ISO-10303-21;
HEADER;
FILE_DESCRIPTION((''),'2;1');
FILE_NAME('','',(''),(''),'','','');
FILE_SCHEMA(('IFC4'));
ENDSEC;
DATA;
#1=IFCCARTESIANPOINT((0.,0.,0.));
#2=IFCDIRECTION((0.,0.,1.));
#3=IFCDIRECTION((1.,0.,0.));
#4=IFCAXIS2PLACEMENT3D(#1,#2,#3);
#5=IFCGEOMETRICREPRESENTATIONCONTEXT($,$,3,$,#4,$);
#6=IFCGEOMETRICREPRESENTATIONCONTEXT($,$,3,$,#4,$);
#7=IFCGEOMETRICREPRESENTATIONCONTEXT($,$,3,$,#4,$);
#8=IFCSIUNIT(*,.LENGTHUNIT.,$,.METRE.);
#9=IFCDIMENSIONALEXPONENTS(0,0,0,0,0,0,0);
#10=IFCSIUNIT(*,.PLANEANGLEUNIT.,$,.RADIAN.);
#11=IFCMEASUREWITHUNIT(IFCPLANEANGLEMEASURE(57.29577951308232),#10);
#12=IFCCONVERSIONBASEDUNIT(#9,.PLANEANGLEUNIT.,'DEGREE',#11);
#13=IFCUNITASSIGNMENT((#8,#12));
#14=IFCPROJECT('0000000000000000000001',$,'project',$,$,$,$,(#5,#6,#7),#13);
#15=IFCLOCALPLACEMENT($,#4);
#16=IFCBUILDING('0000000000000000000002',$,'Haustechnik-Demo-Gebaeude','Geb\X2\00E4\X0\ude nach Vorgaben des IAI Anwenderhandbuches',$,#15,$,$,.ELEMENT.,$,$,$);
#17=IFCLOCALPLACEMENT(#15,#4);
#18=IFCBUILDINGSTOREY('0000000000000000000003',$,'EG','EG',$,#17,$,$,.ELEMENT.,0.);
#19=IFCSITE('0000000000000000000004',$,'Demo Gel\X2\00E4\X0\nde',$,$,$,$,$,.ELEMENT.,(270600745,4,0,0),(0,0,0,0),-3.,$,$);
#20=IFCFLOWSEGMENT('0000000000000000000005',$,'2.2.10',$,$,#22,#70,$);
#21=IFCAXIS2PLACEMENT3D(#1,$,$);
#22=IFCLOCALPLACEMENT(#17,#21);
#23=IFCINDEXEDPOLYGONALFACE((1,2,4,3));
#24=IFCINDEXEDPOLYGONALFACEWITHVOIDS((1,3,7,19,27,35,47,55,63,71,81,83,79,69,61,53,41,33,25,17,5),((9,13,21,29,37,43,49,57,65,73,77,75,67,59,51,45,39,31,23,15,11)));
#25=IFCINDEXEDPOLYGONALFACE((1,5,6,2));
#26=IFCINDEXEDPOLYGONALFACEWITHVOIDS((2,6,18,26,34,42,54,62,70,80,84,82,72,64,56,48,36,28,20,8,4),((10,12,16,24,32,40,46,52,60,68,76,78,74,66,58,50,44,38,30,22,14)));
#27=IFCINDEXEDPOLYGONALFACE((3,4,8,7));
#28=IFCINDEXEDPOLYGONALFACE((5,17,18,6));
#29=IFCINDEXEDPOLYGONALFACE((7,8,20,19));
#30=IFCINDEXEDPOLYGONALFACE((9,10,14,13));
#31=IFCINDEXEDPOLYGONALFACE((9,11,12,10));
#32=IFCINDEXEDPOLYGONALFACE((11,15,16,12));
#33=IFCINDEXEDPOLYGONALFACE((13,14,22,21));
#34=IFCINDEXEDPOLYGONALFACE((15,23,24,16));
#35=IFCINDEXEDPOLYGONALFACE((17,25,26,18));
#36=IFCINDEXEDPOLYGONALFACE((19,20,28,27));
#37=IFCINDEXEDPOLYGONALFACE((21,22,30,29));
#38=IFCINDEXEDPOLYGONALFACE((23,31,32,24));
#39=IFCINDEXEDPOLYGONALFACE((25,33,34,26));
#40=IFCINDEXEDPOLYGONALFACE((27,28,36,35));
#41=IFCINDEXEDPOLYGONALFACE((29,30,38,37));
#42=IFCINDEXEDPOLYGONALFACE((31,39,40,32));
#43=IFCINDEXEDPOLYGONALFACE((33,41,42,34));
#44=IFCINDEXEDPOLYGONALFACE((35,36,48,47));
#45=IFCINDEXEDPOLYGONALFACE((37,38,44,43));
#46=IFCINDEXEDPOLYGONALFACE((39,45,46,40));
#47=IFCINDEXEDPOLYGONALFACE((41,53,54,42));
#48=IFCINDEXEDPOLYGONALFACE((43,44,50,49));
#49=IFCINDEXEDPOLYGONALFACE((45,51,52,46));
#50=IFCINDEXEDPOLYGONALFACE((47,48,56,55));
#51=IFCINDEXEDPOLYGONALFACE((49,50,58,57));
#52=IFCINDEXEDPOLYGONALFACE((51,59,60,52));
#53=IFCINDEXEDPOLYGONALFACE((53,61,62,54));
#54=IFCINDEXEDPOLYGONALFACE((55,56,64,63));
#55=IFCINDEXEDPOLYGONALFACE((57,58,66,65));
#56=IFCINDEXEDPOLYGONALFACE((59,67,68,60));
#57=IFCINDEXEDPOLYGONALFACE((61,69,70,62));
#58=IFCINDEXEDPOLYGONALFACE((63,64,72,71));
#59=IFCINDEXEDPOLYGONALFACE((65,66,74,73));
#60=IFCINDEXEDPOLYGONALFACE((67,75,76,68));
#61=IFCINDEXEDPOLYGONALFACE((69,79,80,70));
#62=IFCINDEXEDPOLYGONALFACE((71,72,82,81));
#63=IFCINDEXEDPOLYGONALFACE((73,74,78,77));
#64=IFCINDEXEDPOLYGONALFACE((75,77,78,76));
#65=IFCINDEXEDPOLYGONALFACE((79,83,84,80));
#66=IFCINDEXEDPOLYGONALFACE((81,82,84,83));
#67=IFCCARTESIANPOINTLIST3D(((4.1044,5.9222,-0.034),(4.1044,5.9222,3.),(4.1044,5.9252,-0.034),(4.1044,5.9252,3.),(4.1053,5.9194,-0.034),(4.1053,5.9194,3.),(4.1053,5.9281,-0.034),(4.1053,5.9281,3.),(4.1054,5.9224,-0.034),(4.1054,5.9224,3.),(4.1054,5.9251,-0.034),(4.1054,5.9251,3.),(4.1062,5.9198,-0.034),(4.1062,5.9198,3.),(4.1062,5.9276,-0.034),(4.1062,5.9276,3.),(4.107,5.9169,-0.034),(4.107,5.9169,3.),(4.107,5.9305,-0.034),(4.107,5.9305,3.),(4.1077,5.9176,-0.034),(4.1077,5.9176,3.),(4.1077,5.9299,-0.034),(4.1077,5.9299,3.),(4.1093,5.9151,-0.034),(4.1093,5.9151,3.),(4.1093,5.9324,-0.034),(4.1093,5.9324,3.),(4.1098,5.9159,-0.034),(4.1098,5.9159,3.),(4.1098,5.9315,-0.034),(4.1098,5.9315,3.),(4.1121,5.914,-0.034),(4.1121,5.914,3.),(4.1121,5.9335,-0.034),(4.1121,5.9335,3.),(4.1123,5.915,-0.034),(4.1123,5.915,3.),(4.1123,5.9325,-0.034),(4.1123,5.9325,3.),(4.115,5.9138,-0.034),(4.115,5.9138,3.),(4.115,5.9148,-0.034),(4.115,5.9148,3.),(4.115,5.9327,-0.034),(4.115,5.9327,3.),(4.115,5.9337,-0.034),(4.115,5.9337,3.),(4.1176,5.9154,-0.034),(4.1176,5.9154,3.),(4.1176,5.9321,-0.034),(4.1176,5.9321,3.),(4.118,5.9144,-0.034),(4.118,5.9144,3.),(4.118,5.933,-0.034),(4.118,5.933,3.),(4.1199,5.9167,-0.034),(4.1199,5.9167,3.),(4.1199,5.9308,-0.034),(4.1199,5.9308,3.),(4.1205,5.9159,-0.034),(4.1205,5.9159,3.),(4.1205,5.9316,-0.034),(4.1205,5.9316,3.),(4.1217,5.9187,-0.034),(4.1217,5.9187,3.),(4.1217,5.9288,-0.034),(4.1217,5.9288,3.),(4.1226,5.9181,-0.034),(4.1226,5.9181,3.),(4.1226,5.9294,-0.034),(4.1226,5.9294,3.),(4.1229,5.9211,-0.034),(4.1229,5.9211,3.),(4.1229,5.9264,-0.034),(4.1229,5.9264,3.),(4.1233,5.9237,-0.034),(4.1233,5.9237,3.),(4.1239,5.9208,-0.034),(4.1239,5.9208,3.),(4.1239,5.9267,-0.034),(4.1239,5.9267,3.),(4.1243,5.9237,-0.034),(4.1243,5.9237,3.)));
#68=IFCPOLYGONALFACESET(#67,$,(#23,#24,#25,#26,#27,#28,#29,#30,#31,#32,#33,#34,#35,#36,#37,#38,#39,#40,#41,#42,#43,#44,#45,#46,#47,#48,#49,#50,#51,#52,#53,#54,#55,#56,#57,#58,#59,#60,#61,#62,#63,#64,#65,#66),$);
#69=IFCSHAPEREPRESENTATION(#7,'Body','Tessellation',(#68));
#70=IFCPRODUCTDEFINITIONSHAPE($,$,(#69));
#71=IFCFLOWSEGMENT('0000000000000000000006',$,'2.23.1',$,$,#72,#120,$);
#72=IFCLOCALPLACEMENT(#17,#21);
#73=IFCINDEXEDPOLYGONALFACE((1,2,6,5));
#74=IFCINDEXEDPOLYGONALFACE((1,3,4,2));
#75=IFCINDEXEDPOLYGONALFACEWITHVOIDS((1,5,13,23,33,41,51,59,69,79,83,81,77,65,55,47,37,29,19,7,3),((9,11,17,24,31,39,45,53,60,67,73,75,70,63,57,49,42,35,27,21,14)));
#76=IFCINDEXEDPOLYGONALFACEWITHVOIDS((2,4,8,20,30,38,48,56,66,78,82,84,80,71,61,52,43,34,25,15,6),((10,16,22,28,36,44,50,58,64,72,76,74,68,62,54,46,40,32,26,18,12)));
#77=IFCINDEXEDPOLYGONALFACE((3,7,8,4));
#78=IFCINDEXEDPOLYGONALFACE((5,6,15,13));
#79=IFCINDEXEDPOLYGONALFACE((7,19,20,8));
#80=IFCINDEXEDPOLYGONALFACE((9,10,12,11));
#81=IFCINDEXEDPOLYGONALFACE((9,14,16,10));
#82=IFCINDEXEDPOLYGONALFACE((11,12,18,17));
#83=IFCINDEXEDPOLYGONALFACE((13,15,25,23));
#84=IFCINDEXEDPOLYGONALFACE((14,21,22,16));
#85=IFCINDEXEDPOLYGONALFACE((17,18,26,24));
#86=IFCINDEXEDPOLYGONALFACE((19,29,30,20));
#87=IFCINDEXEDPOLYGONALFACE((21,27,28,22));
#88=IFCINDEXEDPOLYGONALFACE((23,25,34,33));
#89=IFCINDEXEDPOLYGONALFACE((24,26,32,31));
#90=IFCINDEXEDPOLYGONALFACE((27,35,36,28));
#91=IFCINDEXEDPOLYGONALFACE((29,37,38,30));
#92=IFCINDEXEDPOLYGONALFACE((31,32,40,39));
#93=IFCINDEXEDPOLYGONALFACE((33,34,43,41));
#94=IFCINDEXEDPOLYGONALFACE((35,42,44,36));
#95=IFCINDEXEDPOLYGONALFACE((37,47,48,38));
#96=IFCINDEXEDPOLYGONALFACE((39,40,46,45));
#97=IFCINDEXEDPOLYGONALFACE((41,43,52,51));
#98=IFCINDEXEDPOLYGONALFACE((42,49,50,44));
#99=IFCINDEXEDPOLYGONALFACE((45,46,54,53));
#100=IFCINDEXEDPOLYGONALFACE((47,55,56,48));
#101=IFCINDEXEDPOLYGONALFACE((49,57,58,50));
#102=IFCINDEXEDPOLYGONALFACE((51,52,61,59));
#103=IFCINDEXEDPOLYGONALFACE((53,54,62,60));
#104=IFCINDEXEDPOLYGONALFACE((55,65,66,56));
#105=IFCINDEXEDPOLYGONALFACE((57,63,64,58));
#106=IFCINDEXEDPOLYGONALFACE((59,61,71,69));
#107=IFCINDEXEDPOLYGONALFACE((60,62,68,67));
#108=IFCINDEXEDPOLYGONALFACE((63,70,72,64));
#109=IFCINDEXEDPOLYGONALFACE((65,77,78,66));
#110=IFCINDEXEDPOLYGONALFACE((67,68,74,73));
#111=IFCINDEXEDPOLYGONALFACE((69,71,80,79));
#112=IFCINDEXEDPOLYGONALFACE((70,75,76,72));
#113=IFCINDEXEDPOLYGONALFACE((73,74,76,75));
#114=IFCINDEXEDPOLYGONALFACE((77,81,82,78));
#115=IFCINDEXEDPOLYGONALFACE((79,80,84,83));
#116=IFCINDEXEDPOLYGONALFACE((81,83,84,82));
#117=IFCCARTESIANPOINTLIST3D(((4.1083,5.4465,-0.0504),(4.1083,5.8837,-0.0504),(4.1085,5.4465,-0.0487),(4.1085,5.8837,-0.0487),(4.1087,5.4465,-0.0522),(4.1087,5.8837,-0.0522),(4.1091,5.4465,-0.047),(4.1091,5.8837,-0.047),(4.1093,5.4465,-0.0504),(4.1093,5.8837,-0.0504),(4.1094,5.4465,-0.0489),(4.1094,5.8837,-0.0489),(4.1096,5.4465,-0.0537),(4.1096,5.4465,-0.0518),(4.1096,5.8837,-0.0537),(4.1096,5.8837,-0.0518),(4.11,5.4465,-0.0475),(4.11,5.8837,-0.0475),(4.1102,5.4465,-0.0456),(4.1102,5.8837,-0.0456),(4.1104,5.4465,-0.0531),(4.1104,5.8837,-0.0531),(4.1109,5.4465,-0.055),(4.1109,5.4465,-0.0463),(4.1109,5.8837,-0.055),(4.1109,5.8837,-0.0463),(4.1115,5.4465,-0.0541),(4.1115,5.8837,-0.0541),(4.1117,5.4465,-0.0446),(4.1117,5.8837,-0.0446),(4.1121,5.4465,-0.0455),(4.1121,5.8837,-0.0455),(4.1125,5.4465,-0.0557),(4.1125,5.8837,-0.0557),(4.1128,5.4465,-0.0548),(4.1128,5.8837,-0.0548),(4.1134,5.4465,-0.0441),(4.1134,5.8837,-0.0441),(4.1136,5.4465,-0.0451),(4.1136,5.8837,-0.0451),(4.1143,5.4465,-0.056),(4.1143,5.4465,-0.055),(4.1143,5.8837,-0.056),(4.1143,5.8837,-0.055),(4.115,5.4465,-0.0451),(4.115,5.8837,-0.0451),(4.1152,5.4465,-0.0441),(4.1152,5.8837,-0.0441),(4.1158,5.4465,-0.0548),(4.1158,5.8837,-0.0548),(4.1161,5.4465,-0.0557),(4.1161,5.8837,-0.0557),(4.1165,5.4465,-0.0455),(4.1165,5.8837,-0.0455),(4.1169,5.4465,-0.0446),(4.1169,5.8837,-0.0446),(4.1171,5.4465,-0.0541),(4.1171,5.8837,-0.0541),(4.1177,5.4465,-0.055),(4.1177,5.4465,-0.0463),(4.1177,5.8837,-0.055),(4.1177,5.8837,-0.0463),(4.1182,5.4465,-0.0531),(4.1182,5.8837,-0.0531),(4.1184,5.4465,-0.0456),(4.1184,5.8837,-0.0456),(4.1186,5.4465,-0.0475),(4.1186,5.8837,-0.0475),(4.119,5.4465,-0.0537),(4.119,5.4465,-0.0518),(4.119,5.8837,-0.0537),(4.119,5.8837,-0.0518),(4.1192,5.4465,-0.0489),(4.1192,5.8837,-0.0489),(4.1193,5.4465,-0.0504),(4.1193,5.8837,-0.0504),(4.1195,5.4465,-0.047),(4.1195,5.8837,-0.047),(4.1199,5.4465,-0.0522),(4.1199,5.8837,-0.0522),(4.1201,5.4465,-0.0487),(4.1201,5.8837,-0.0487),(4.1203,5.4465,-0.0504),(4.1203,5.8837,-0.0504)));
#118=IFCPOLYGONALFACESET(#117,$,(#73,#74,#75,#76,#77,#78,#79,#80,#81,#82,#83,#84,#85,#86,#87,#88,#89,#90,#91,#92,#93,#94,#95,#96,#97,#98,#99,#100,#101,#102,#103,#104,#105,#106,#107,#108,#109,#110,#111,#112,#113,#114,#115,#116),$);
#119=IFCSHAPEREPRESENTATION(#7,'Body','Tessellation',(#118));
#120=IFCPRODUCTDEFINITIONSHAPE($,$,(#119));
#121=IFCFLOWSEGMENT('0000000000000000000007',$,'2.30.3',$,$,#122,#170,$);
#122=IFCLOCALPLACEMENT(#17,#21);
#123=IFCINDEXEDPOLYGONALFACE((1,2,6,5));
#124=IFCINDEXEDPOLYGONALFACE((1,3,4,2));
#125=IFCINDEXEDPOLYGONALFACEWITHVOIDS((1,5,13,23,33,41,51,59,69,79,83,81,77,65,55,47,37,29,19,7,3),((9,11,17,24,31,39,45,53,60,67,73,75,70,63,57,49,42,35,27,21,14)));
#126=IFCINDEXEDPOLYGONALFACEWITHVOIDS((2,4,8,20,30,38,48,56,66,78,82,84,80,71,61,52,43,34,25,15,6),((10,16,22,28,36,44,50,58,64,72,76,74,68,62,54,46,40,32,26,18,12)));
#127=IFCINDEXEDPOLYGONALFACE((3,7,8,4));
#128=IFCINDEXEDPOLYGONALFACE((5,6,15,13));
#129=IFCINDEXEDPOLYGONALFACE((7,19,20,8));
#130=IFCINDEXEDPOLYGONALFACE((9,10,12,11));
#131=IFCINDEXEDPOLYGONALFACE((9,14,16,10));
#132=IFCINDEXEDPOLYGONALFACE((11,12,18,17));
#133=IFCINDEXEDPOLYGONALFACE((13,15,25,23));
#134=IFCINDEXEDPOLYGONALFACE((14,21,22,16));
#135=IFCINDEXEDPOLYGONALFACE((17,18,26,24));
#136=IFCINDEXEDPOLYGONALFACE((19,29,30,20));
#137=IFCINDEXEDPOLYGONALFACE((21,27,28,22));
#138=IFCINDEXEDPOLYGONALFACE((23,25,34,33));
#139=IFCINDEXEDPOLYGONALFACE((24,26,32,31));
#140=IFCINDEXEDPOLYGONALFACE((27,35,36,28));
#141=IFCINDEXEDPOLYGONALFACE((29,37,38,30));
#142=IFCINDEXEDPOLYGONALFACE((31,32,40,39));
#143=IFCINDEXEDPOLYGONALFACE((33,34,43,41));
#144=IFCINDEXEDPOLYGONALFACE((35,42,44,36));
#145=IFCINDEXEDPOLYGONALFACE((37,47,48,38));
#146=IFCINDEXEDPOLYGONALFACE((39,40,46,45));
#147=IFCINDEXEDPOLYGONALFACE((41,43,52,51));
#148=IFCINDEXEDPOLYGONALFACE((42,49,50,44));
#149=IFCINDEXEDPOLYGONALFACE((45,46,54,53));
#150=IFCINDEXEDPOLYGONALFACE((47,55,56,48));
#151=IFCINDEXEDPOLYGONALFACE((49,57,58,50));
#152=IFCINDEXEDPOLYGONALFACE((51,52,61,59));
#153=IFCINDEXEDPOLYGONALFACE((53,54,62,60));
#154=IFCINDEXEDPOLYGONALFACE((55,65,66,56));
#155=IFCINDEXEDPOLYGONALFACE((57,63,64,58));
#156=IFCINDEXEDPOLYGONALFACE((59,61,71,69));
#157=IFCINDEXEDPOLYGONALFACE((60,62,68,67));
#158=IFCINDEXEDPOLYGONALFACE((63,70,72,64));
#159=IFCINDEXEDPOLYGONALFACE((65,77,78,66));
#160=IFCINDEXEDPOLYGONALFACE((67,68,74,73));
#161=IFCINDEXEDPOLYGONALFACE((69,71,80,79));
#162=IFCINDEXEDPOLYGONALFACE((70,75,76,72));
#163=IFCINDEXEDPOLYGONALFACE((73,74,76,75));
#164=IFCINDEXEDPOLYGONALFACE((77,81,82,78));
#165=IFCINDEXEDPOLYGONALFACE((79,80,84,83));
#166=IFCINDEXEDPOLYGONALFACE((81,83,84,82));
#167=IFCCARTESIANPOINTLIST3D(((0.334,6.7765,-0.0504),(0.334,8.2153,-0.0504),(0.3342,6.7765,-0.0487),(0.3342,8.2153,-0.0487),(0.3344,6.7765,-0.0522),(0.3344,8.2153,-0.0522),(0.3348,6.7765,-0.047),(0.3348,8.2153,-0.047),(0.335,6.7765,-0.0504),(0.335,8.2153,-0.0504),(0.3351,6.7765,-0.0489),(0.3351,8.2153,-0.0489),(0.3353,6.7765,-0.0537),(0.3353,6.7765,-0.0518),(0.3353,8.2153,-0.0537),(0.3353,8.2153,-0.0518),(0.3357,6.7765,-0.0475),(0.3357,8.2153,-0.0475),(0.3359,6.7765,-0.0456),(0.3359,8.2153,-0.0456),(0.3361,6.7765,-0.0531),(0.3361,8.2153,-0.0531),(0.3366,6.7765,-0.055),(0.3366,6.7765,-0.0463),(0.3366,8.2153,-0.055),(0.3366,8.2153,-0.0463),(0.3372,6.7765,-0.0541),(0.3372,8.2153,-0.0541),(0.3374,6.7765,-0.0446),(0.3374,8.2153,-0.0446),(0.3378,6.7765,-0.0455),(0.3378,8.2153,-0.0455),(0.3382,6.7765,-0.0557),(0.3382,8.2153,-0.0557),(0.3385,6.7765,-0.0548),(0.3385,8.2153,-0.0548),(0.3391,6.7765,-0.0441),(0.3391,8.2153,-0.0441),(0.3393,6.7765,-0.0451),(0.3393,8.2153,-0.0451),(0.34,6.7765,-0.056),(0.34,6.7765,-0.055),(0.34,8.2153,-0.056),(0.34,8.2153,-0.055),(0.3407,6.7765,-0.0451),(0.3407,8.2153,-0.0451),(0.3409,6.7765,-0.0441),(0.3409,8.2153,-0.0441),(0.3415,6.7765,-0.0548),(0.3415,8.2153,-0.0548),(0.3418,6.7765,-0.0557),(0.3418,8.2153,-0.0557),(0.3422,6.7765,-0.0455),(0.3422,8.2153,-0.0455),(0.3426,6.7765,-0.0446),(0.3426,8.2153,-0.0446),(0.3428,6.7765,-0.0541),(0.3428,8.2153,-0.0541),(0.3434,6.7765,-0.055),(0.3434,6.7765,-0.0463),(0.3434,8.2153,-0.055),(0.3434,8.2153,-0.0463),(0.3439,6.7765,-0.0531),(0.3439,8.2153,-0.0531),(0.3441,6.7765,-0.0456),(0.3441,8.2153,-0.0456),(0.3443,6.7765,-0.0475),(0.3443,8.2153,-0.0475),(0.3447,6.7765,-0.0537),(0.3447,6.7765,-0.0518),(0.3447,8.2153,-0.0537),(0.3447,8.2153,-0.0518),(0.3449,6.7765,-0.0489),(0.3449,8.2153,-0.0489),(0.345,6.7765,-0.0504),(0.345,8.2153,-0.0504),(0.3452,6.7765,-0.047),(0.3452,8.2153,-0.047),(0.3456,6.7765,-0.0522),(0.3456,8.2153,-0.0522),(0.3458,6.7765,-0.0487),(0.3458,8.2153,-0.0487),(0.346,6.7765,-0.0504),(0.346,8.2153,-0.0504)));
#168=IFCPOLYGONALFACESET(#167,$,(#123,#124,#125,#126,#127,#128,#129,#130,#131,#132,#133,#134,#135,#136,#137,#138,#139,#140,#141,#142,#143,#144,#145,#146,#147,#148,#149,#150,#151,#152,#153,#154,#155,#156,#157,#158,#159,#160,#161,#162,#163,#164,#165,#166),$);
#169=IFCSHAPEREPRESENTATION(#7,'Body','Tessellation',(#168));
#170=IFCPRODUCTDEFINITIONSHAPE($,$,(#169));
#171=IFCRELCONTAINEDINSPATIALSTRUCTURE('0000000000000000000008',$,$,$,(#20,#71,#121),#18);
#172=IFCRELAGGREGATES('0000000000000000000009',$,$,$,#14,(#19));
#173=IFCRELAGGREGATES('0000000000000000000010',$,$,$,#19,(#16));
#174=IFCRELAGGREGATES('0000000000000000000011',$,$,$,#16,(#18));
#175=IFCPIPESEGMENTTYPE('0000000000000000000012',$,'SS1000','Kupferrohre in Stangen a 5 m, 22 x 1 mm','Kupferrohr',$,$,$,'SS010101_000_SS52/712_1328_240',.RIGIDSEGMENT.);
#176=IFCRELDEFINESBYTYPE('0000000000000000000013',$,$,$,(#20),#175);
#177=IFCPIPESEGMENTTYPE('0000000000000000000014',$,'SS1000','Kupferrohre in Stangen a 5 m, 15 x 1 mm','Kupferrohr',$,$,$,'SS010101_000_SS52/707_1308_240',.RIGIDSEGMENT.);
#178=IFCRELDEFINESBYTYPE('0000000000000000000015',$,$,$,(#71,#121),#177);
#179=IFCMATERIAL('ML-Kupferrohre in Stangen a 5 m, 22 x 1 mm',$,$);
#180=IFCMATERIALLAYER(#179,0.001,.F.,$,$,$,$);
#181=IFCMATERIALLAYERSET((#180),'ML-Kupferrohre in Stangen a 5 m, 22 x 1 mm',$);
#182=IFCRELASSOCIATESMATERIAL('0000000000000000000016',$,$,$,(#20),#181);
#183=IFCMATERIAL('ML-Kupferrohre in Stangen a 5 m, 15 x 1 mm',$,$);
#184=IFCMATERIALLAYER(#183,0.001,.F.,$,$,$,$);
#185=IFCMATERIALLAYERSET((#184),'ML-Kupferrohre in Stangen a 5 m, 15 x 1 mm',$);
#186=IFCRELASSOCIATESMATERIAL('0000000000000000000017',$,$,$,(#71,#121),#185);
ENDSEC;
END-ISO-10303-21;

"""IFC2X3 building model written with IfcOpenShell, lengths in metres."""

from ifc_helpers import new_model, entity, si_unit, converted_unit, frame, origin_with_axes, origin_2d_with_axis, place, context, project, spatial, hollow_circle, extrude, material, layer, layer_set, layer_usage, type_object, element, save


model = new_model("IFC2X3")

# Units and contexts
context_of_model_1 = context(None, 3, world=origin_with_axes())
context_of_model_2 = context(None, 3, world=origin_with_axes())
context_of_model_3 = context(None, 3, world=origin_with_axes())
ifc_project = project(units=[si_unit("LENGTHUNIT", "METRE"), converted_unit("PLANEANGLEUNIT", "DEGREE", entity("IfcPlaneAngleMeasure", 57.29577951308232), si_unit("PLANEANGLEUNIT", "RADIAN"), dimensions=[0, 0, 0, 0, 0, 0, 0])], contexts=[context_of_model_1, context_of_model_2, context_of_model_3])

# Site, building, storey
site = spatial("IfcSite", under=ifc_project, Name="Demo Gelände", CompositionType="ELEMENT", RefLatitude=(270600745, 4, 0, 0), RefLongitude=(0, 0, 0, 0), RefElevation=-3.0)
building_placement = place(None, origin_with_axes())
building = spatial("IfcBuilding", under=site, at=building_placement, Name="Haustechnik-Demo-Gebaeude", Description="Gebäude nach Vorgaben des IAI Anwenderhandbuches", CompositionType="ELEMENT")
storey_placement = place(building_placement, origin_with_axes())
storey = spatial("IfcBuildingStorey", under=building, at=storey_placement, Name="EG", Description="EG", CompositionType="ELEMENT", Elevation=0.0)

# Flow segments
ifc_material_1 = material(Name="ML-Kupferrohre in Stangen a 5 m, 22 x 1 mm")
ifc_layer_1 = layer(ifc_material_1, 0.001, ventilated=False)
ifc_layer_set_1 = layer_set([ifc_layer_1], Name="ML-Kupferrohre in Stangen a 5 m, 22 x 1 mm")
ifc_layer_usage_1 = layer_usage(ifc_layer_set_1, "AXIS2", "POSITIVE", 0.0)
pipe_segment_type_1 = type_object("IfcPipeSegmentType", Name="SS1000", Description="Kupferrohre in Stangen a 5 m, 22 x 1 mm", ApplicableOccurrence="Kupferrohr", ElementType="SS010101_000_SS52/712_1328_240", PredefinedType="RIGIDSEGMENT")
flow_segment_1_placement = place(storey_placement, frame((4.1143, 5.9237, -0.034), z_axis=(0.0, 0.0, 1.0), x_axis=(1.0, 0.0, 0.0)))
element("IfcFlowSegment", 1, at=flow_segment_1_placement, inside=storey, type_object=pipe_segment_type_1, material=ifc_layer_usage_1, Name="2.2.10", context=context_of_model_3, shape_type="SweptSolid", body=[
    extrude(hollow_circle(Radius=0.01, WallThickness=0.001, at=origin_2d_with_axis()), origin_with_axes(), (0.0, 0.0, 1.0), 3.034),
])
ifc_material_2 = material(Name="ML-Kupferrohre in Stangen a 5 m, 15 x 1 mm")
ifc_layer_2 = layer(ifc_material_2, 0.001, ventilated=False)
ifc_layer_set_2 = layer_set([ifc_layer_2], Name="ML-Kupferrohre in Stangen a 5 m, 15 x 1 mm")
ifc_layer_usage_2 = layer_usage(ifc_layer_set_2, "AXIS2", "POSITIVE", 0.0)
pipe_segment_type_2 = type_object("IfcPipeSegmentType", Name="SS1000", Description="Kupferrohre in Stangen a 5 m, 15 x 1 mm", ApplicableOccurrence="Kupferrohr", ElementType="SS010101_000_SS52/707_1308_240", PredefinedType="RIGIDSEGMENT")
flow_segment_2_placement = place(storey_placement, frame((4.1143, 5.8837, -0.05), z_axis=(0.0, -1.0, 0.0), x_axis=(0.0, 0.0, -1.0)))
element("IfcFlowSegment", 2, at=flow_segment_2_placement, inside=storey, type_object=pipe_segment_type_2, material=ifc_layer_usage_2, Name="2.23.1", context=context_of_model_3, shape_type="SweptSolid", body=[
    extrude(hollow_circle(Radius=0.006, WallThickness=0.001, at=origin_2d_with_axis()), origin_with_axes(), (0.0, 0.0, 1.0), 0.4372),
])
flow_segment_3_placement = place(storey_placement, frame((0.34, 6.7765, -0.05), z_axis=(0.0, 1.0, 0.0), x_axis=(0.0, 0.0, -1.0)))
element("IfcFlowSegment", 3, at=flow_segment_3_placement, inside=storey, type_object=pipe_segment_type_2, material=ifc_layer_usage_2, Name="2.30.3", context=context_of_model_3, shape_type="SweptSolid", body=[
    extrude(hollow_circle(Radius=0.006, WallThickness=0.001, at=origin_2d_with_axis()), origin_with_axes(), (0.0, 0.0, 1.0), 1.4388),
])

save(model, "model.ifc")
